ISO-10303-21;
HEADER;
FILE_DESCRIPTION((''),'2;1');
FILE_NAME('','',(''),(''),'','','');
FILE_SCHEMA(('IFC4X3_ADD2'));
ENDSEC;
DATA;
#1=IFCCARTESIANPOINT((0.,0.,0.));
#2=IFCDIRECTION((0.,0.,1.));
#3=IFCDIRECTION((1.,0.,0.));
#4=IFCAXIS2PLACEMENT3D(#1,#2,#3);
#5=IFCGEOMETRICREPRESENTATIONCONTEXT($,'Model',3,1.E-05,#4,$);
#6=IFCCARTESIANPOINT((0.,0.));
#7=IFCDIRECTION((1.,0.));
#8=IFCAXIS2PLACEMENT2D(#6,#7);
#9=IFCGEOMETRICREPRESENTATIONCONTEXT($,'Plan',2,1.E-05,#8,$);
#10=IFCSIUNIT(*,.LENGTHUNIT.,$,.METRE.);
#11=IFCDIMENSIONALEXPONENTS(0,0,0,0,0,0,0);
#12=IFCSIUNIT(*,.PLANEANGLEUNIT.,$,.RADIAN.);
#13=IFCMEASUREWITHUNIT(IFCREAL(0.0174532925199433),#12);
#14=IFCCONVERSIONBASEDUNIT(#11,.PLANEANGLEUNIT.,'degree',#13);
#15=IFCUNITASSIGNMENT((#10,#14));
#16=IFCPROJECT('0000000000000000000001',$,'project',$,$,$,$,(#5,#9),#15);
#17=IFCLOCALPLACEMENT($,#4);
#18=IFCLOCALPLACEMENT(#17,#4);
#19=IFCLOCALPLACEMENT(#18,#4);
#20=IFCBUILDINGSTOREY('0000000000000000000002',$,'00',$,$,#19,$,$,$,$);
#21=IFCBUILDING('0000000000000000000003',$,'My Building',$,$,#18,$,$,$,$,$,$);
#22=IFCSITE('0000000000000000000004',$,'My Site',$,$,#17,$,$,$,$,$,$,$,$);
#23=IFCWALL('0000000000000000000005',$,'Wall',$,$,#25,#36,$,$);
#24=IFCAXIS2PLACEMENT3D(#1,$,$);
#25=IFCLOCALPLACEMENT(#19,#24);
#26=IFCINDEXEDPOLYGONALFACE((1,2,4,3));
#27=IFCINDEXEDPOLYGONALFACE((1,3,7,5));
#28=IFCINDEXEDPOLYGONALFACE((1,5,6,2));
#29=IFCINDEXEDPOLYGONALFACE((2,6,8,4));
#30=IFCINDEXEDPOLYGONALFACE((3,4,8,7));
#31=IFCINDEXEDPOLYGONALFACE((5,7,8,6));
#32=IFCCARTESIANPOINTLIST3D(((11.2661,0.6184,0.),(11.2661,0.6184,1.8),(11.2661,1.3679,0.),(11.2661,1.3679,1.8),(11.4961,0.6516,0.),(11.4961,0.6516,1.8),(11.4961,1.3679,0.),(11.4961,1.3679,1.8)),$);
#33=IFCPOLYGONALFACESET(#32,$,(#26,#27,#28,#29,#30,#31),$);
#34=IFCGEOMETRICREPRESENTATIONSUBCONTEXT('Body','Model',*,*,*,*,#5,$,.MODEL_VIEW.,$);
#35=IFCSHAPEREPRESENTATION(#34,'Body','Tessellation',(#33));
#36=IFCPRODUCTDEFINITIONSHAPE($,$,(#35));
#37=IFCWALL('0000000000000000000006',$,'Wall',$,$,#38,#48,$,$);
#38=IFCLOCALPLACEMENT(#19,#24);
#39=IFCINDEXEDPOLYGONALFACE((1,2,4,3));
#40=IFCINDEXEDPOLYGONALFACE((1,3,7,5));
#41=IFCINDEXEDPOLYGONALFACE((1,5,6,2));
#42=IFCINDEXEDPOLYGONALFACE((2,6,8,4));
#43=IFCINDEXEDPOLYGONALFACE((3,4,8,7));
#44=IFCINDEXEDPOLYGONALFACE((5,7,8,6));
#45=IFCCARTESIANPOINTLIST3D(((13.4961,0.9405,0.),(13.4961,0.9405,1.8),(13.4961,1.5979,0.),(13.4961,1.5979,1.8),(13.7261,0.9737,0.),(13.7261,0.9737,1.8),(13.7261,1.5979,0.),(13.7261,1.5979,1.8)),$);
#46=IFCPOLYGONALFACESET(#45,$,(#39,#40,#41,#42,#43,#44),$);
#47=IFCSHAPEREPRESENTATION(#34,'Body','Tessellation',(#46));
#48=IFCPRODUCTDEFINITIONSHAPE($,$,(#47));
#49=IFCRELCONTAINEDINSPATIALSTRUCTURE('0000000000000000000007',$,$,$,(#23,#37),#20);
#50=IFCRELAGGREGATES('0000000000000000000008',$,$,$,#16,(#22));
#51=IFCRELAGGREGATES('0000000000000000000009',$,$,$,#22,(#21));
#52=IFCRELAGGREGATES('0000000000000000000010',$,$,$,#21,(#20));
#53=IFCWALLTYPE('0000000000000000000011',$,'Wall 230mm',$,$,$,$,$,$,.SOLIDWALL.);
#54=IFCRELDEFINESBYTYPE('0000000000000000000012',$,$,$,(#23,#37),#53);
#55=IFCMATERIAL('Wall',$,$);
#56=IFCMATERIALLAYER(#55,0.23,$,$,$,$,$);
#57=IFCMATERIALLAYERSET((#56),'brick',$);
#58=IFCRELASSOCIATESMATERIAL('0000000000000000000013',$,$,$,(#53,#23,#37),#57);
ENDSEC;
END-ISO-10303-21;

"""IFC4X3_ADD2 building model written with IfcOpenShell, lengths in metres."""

from ifc_helpers import new_model, entity, si_unit, converted_unit, frame, origin_with_axes, origin_2d_with_axis, place, context, subcontext, project, spatial, indexed_curve, outline, extrude, clip, halfspace, material, layer, layer_set, layer_usage, type_object, element, save


model = new_model("IFC4X3_ADD2")

# Units and contexts
model_context = context("Model", 3, precision=1e-05, world=origin_with_axes())
plan_context = context("Plan", 2, precision=1e-05, world=origin_2d_with_axis())
body_context_1 = subcontext(model_context, "Body", "Model", "MODEL_VIEW")
ifc_project = project(units=[si_unit("LENGTHUNIT", "METRE"), converted_unit("PLANEANGLEUNIT", "degree", entity("IfcReal", 0.0174532925199433), si_unit("PLANEANGLEUNIT", "RADIAN"), dimensions=[0, 0, 0, 0, 0, 0, 0])], contexts=[model_context, plan_context])

# Site, building, storey
site_placement = place(None, origin_with_axes())
site = spatial("IfcSite", under=ifc_project, at=site_placement, Name="My Site")
building_placement = place(site_placement, origin_with_axes())
building = spatial("IfcBuilding", under=site, at=building_placement, Name="My Building")
storey_placement = place(building_placement, origin_with_axes())
storey = spatial("IfcBuildingStorey", under=building, at=storey_placement, Name="00")

# Shared definitions
ifc_material_1 = material(Name="Wall")
ifc_layer_1 = layer(ifc_material_1, 0.23)
ifc_layer_set_1 = layer_set([ifc_layer_1], Name="brick")
wall_type_1 = type_object("IfcWallType", Name="Wall 230mm", PredefinedType="SOLIDWALL", material=ifc_layer_set_1)

# Walls
ifc_layer_usage_1 = layer_usage(ifc_layer_set_1, "AXIS2", "POSITIVE", 0.0)
wall_1_placement = place(storey_placement, frame((11.4961, 0.6184, 0.0), z_axis=(0.0, 0.0, 1.0), x_axis=(0.000001, 1.0, 0.0)))
element("IfcWall", 1, at=wall_1_placement, inside=storey, type_object=wall_type_1, material=ifc_layer_usage_1, Name="Wall", context=body_context_1, shape_type="Clipping", body=[
    clip(extrude(outline(indexed_curve([(0.0, 0.0), (0.0, 0.23), (0.7495, 0.23), (0.7495, 0.0), (0.0, 0.0)], self_intersect=False)), origin_with_axes(), (0.0, 0.0, 1.0), 1.8), halfspace(frame((0.0332, 0.0, 0.0), z_axis=(-0.574996, -0.083058, 0.0), x_axis=(-0.142966, 0.989728, 0.0)), False)),
])
ifc_layer_usage_2 = layer_usage(ifc_layer_set_1, "AXIS2", "POSITIVE", 0.0)
wall_2_placement = place(storey_placement, frame((13.7261, 0.9405, 0.0), z_axis=(0.0, 0.0, 1.0), x_axis=(0.000001, 1.0, 0.0)))
element("IfcWall", 2, at=wall_2_placement, inside=storey, type_object=wall_type_1, material=ifc_layer_usage_2, Name="Wall", context=body_context_1, shape_type="Clipping", body=[
    clip(extrude(outline(indexed_curve([(0.0, 0.0), (0.0, 0.23), (0.6574, 0.23), (0.6574, 0.0), (0.0, 0.0)], self_intersect=False)), origin_with_axes(), (0.0, 0.0, 1.0), 1.8), halfspace(frame((0.0332, 0.0, 0.0), z_axis=(-0.574999, -0.083059, 0.0), x_axis=(-0.142966, 0.989728, 0.0)), False)),
])

save(model, "model.ifc")
